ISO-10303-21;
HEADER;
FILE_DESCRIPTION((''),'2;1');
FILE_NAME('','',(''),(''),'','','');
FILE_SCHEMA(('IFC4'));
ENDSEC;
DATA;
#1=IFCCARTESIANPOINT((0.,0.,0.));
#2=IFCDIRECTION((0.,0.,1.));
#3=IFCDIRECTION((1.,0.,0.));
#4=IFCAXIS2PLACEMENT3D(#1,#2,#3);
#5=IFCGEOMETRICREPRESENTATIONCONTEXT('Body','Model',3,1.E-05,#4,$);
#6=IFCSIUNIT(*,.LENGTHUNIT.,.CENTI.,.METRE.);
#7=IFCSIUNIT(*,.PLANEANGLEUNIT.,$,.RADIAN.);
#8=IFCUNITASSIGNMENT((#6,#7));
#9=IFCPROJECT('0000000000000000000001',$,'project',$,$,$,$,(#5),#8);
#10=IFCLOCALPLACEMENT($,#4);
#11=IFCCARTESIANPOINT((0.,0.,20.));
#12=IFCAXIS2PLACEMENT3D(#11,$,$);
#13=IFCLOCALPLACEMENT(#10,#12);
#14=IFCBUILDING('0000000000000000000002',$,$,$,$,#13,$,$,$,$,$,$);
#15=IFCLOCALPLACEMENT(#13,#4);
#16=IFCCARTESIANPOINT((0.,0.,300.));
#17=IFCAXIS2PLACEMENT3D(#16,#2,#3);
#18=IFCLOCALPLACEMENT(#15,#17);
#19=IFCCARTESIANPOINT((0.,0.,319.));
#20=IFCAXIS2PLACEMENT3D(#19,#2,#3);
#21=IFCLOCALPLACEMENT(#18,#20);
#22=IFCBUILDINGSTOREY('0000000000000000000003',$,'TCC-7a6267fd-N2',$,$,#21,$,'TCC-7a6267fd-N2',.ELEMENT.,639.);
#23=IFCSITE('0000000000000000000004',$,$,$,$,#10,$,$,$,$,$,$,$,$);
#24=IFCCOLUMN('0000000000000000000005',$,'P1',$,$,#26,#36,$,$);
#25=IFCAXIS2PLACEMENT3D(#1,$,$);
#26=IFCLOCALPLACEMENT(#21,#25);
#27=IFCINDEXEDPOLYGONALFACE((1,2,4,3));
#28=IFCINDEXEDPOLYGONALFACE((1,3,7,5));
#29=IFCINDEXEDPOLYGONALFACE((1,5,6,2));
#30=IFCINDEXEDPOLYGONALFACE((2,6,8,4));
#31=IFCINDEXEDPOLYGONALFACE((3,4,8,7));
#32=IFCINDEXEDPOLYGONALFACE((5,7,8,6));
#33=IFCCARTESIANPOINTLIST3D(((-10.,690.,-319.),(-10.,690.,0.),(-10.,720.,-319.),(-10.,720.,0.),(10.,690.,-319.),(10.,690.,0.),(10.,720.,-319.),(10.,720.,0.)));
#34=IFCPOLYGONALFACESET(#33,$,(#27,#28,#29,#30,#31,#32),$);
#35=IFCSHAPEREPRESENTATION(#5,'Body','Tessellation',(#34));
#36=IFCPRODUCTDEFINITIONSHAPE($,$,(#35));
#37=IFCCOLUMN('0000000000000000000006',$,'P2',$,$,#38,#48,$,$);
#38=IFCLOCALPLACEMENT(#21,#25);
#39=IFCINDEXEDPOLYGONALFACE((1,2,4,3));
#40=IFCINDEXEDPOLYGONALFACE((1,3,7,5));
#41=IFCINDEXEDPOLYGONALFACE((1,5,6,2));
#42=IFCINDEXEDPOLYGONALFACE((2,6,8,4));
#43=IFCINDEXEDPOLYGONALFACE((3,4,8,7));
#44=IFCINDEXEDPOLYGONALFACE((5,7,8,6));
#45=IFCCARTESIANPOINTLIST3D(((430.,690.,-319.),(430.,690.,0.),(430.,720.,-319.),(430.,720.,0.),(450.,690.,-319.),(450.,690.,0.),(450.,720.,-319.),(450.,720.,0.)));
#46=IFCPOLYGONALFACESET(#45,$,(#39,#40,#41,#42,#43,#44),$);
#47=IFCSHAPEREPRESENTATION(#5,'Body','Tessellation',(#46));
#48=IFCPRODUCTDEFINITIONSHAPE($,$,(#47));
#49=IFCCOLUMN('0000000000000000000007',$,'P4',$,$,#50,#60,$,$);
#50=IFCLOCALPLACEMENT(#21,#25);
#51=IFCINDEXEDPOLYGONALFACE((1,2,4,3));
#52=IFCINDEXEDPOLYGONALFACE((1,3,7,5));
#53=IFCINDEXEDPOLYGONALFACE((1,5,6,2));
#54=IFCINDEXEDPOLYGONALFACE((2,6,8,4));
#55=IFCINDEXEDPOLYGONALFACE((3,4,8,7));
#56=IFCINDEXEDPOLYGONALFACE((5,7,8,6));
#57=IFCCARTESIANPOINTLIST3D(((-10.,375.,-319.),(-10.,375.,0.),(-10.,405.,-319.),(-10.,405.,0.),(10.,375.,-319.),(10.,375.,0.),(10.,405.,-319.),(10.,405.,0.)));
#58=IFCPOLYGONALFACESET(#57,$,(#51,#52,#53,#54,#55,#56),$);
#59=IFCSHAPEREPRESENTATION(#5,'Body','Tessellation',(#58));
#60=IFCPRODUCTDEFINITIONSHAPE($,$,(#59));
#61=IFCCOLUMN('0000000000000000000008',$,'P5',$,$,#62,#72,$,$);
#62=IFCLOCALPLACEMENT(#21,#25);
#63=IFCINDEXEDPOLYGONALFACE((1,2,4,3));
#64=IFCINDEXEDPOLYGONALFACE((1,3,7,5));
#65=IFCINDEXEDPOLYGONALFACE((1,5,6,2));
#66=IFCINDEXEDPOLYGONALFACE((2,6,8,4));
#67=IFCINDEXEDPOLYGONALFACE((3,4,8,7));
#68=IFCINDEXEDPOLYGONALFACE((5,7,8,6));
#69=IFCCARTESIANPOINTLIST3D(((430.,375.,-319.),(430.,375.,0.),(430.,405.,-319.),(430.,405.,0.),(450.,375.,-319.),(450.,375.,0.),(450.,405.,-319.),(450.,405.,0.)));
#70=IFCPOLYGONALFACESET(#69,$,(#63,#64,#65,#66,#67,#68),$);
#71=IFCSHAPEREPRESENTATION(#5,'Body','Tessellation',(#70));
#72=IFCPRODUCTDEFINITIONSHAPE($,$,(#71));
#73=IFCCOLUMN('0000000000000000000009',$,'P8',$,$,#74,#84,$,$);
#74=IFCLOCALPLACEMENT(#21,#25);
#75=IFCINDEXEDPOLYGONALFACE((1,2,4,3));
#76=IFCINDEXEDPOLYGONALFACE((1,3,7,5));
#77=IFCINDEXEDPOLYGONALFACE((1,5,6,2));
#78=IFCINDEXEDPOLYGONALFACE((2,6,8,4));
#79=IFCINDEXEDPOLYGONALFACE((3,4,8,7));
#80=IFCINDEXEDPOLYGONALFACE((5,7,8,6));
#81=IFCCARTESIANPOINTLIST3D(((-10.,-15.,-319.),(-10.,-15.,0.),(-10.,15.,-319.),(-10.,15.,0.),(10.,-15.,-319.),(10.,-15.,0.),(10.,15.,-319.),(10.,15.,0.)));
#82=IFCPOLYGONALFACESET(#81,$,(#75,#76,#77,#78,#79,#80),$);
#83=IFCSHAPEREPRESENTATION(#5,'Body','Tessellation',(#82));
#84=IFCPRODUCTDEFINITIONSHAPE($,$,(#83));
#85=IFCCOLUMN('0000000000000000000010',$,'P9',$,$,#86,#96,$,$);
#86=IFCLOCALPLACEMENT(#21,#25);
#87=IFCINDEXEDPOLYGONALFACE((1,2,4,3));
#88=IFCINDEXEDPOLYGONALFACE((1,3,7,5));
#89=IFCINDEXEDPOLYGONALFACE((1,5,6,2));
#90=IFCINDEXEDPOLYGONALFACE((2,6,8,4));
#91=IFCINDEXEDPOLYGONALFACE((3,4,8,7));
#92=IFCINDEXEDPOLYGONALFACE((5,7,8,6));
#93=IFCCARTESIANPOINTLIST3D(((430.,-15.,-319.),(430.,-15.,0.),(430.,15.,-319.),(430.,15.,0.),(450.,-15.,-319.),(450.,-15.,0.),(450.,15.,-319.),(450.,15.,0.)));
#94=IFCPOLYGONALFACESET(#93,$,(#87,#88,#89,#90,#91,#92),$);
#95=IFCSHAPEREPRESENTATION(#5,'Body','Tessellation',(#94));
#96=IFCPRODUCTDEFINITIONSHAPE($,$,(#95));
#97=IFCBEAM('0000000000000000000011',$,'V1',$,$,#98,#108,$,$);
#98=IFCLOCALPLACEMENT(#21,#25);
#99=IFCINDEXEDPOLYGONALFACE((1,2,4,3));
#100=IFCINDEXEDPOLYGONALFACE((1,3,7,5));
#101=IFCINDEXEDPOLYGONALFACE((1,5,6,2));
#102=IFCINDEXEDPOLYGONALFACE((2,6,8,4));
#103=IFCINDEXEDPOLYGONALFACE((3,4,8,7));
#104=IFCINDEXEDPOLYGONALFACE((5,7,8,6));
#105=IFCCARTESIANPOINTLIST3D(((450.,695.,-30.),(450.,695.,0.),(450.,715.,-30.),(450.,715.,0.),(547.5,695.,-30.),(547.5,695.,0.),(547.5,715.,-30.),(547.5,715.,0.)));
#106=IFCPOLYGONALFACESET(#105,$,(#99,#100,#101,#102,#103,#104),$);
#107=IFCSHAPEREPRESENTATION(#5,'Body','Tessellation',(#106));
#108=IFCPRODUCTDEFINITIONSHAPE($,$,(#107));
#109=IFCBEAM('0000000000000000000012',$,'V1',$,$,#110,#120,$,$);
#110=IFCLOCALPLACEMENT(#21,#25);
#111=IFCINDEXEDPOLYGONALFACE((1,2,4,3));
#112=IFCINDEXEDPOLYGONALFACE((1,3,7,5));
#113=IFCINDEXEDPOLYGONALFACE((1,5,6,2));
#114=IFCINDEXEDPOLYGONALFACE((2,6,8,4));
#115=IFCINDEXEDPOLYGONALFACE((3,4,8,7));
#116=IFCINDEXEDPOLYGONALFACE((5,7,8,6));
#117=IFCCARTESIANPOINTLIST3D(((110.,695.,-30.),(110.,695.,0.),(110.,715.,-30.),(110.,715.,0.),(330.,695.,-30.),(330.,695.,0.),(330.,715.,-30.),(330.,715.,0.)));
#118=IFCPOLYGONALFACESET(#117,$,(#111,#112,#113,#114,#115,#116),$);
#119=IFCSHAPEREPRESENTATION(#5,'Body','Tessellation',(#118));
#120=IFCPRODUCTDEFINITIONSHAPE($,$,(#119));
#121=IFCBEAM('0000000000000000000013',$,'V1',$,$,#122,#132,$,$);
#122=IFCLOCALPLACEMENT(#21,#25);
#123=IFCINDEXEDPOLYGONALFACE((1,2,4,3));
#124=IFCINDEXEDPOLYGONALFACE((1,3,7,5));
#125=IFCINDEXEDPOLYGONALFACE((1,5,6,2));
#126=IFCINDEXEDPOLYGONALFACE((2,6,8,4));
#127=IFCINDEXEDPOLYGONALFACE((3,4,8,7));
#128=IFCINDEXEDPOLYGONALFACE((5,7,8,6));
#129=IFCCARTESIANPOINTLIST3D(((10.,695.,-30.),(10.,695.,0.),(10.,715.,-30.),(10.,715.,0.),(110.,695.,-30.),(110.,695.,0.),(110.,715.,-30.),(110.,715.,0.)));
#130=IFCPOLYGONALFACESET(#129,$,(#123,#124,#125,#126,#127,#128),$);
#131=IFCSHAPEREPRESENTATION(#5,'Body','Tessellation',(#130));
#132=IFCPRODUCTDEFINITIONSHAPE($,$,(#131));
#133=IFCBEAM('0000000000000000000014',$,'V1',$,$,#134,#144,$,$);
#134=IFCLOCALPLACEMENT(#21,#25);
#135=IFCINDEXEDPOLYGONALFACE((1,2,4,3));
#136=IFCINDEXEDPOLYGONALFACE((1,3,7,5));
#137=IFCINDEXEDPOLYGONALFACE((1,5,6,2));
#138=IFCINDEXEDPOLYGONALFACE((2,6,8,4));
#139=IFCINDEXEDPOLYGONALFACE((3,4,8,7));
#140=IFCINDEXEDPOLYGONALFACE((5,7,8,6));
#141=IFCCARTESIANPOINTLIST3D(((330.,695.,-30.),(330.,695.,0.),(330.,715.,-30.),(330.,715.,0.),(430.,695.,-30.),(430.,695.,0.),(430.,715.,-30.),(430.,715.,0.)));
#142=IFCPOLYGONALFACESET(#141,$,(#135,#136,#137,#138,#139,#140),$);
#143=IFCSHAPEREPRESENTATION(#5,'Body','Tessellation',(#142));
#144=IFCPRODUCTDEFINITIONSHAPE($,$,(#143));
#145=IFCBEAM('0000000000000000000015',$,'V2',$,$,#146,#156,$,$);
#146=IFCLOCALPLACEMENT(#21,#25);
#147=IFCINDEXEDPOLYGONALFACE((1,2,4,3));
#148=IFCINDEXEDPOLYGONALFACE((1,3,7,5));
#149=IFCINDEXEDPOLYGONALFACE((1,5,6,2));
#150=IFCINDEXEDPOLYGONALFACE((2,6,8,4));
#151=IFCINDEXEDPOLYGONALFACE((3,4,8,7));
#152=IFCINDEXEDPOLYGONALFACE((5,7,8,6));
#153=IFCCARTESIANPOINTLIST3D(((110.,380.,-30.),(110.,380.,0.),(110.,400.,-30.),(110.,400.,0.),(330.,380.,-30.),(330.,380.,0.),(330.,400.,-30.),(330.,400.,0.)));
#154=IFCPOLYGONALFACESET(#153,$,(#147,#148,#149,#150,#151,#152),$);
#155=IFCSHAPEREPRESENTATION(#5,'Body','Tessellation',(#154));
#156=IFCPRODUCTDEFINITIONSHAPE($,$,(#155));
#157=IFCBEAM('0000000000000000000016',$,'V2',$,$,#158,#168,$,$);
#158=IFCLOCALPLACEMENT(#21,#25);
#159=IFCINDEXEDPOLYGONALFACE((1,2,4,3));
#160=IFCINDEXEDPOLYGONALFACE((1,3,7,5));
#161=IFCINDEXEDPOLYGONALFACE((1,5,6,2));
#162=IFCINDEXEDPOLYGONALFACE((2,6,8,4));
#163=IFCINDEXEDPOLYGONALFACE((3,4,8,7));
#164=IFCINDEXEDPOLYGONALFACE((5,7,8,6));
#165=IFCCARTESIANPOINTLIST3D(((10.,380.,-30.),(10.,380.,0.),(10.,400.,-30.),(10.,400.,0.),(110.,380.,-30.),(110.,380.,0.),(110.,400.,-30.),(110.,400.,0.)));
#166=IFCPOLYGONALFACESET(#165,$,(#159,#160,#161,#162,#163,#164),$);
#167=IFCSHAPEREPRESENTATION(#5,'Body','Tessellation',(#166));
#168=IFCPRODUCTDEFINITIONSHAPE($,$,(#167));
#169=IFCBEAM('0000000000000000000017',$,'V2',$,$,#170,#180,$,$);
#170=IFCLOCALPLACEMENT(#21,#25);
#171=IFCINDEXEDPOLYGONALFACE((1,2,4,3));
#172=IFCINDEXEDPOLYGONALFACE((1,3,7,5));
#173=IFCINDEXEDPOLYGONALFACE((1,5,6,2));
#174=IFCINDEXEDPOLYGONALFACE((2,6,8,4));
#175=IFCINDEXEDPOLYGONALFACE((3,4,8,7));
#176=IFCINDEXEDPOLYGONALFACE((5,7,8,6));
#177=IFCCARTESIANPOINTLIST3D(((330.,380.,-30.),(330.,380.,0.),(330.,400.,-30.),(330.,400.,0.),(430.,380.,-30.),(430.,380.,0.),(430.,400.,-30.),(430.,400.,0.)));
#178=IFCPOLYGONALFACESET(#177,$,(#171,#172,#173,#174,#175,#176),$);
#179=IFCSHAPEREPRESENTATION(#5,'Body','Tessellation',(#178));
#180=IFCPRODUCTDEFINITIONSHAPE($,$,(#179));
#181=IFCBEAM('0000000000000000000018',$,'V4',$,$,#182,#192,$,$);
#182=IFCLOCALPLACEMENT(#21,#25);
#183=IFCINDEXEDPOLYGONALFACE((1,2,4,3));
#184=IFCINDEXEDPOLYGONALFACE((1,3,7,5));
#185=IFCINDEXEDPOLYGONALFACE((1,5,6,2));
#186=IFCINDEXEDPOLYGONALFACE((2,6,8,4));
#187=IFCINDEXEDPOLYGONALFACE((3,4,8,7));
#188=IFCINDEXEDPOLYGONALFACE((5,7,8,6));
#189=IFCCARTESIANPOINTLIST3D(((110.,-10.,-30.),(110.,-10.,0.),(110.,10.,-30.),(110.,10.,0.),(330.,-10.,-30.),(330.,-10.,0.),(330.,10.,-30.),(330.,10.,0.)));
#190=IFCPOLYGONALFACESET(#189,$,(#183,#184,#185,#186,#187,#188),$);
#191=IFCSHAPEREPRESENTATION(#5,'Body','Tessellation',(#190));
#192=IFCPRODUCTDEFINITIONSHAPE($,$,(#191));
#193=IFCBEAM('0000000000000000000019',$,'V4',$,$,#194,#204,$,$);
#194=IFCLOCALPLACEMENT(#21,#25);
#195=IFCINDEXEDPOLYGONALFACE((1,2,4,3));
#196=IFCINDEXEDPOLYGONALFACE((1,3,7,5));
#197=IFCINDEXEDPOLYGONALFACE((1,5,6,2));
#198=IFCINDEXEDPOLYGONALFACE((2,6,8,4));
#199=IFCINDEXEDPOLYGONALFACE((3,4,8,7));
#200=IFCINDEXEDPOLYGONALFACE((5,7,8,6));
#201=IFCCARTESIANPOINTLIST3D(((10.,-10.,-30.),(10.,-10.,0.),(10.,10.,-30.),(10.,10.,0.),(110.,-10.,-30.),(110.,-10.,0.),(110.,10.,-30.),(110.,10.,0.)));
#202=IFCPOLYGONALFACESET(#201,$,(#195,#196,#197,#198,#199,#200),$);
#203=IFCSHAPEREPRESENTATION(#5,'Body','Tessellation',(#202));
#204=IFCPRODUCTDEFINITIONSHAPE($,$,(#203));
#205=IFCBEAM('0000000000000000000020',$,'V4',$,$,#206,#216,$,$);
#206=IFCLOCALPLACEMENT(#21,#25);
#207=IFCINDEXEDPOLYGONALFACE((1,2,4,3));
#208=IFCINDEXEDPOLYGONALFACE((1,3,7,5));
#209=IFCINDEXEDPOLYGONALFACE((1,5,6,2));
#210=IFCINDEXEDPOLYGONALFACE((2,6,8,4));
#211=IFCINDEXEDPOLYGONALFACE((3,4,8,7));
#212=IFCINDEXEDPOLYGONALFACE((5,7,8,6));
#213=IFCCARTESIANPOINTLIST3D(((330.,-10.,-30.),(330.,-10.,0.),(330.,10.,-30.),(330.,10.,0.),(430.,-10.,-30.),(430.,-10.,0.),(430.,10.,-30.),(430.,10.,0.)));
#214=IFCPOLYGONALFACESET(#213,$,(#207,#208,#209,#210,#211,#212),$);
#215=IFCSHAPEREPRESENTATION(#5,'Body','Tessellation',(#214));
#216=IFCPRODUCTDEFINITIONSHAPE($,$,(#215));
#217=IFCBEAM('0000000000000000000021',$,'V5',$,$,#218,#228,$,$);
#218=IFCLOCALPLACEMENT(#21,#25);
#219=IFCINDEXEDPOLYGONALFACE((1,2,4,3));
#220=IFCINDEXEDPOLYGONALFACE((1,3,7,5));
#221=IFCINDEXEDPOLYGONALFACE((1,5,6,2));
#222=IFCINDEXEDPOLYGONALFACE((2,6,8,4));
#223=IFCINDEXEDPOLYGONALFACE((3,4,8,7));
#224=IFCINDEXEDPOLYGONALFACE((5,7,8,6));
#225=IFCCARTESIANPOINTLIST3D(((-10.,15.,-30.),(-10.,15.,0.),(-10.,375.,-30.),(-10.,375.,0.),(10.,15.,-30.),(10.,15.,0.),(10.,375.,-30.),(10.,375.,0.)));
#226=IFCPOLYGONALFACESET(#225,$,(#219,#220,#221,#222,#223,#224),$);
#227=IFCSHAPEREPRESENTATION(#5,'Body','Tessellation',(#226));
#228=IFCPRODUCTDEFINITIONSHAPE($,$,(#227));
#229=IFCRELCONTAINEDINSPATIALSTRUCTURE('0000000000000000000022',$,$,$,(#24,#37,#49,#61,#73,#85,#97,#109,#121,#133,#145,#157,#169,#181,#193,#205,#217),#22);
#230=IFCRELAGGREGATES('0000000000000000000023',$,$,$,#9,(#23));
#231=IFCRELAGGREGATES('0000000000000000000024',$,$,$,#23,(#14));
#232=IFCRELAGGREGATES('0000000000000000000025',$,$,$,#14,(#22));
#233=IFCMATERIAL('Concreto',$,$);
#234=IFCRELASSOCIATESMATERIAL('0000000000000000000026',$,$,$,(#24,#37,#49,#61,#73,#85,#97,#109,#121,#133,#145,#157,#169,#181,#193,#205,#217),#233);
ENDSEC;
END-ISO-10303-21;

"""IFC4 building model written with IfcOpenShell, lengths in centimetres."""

from ifc_helpers import new_model, si_unit, frame, origin_with_axes, origin_2d_with_axis, place, context, project, spatial, rectangle, extrude, material, element, save


model = new_model("IFC4")

# Units and contexts
model_context = context("Model", 3, precision=1e-05, world=origin_with_axes(), identifier="Body")
ifc_project = project(units=[si_unit("LENGTHUNIT", "METRE", prefix="CENTI"), si_unit("PLANEANGLEUNIT", "RADIAN")], contexts=[model_context])

# Site, building, storey
site_placement = place(None, origin_with_axes())
site = spatial("IfcSite", under=ifc_project, at=site_placement)
building_placement = place(site_placement, frame((0.0, 0.0, 20.0)))
building = spatial("IfcBuilding", under=site, at=building_placement)
placement_1 = place(building_placement, origin_with_axes())
placement_2 = place(placement_1, frame((0.0, 0.0, 300.0), z_axis=(0.0, 0.0, 1.0), x_axis=(1.0, 0.0, 0.0)))
storey_placement = place(placement_2, frame((0.0, 0.0, 319.0), z_axis=(0.0, 0.0, 1.0), x_axis=(1.0, 0.0, 0.0)))
storey = spatial("IfcBuildingStorey", under=building, at=storey_placement, Name="TCC-7a6267fd-N2", LongName="TCC-7a6267fd-N2", CompositionType="ELEMENT", Elevation=639.0)

# Columns
ifc_material = material(Name="Concreto")
for number, where, z_axis, x_axis, name in (
    (1, (0.0, 705.0, 0.0), (0.0, 0.0, 1.0), (1.0, 0.0, 0.0), "P1"),
    (2, (440.0, 705.0, 0.0), (0.0, 0.0, 1.0), (1.0, 0.0, 0.0), "P2"),
    (3, (0.0, 390.0, 0.0), (0.0, 0.0, 1.0), (1.0, 0.0, 0.0), "P4"),
    (4, (440.0, 390.0, 0.0), (0.0, 0.0, 1.0), (1.0, 0.0, 0.0), "P5"),
    (5, (0.0, 0.0, 0.0), (0.0, 0.0, 1.0), (1.0, 0.0, 0.0), "P8"),
    (6, (440.0, 0.0, 0.0), (0.0, 0.0, 1.0), (1.0, 0.0, 0.0), "P9"),
):
    element("IfcColumn", number, at=place(storey_placement, frame(where, z_axis=z_axis, x_axis=x_axis)), inside=storey, material=ifc_material, Name=name, context=model_context, shape_type="SolidModel", body=[
        extrude(rectangle(XDim=20.0, YDim=30.0, at=origin_2d_with_axis()), origin_with_axes(), (0.0, 0.0, -1.0), 319.0),
    ])

# Beams
beam_1_placement = place(storey_placement, frame((498.75, 705.0, 0.0), z_axis=(0.0, 0.0, 1.0), x_axis=(1.0, 0.0, 0.0)))
element("IfcBeam", 7, at=beam_1_placement, inside=storey, material=ifc_material, Name="V1", context=model_context, shape_type="SolidModel", body=[
    extrude(rectangle(XDim=20.0, YDim=30.0, at=origin_2d_with_axis()), frame((48.75, 0.0, -15.0), z_axis=(-1.0, 0.0, 0.0), x_axis=(0.0, 1.0, 0.0)), (0.0, 0.0, 1.0), 97.5),
])
beam_2_placement = place(storey_placement, frame((220.0, 705.0, 0.0), z_axis=(0.0, 0.0, 1.0), x_axis=(1.0, 0.0, 0.0)))
element("IfcBeam", 8, at=beam_2_placement, inside=storey, material=ifc_material, Name="V1", context=model_context, shape_type="SolidModel", body=[
    extrude(rectangle(XDim=20.0, YDim=30.0, at=origin_2d_with_axis()), frame((110.0, 0.0, -15.0), z_axis=(-1.0, 0.0, 0.0), x_axis=(0.0, 1.0, 0.0)), (0.0, 0.0, 1.0), 220.0),
])
for number, where, z_axis, x_axis, name in (
    (9, (60.0, 705.0, 0.0), (0.0, 0.0, 1.0), (1.0, 0.0, 0.0), "V1"),
    (10, (380.0, 705.0, 0.0), (0.0, 0.0, 1.0), (1.0, 0.0, 0.0), "V1"),
):
    element("IfcBeam", number, at=place(storey_placement, frame(where, z_axis=z_axis, x_axis=x_axis)), inside=storey, material=ifc_material, Name=name, context=model_context, shape_type="SolidModel", body=[
        extrude(rectangle(XDim=20.0, YDim=30.0, at=origin_2d_with_axis()), frame((50.0, 0.0, -15.0), z_axis=(-1.0, 0.0, 0.0), x_axis=(0.0, 1.0, 0.0)), (0.0, 0.0, 1.0), 100.0),
    ])
beam_3_placement = place(storey_placement, frame((220.0, 390.0, 0.0), z_axis=(0.0, 0.0, 1.0), x_axis=(1.0, 0.0, 0.0)))
element("IfcBeam", 11, at=beam_3_placement, inside=storey, material=ifc_material, Name="V2", context=model_context, shape_type="SolidModel", body=[
    extrude(rectangle(XDim=20.0, YDim=30.0, at=origin_2d_with_axis()), frame((110.0, 0.0, -15.0), z_axis=(-1.0, 0.0, 0.0), x_axis=(0.0, 1.0, 0.0)), (0.0, 0.0, 1.0), 220.0),
])
for number, where, z_axis, x_axis, name in (
    (12, (60.0, 390.0, 0.0), (0.0, 0.0, 1.0), (1.0, 0.0, 0.0), "V2"),
    (13, (380.0, 390.0, 0.0), (0.0, 0.0, 1.0), (1.0, 0.0, 0.0), "V2"),
):
    element("IfcBeam", number, at=place(storey_placement, frame(where, z_axis=z_axis, x_axis=x_axis)), inside=storey, material=ifc_material, Name=name, context=model_context, shape_type="SolidModel", body=[
        extrude(rectangle(XDim=20.0, YDim=30.0, at=origin_2d_with_axis()), frame((50.0, 0.0, -15.0), z_axis=(-1.0, 0.0, 0.0), x_axis=(0.0, 1.0, 0.0)), (0.0, 0.0, 1.0), 100.0),
    ])
beam_4_placement = place(storey_placement, frame((220.0, 0.0, 0.0), z_axis=(0.0, 0.0, 1.0), x_axis=(1.0, 0.0, 0.0)))
element("IfcBeam", 14, at=beam_4_placement, inside=storey, material=ifc_material, Name="V4", context=model_context, shape_type="SolidModel", body=[
    extrude(rectangle(XDim=20.0, YDim=30.0, at=origin_2d_with_axis()), frame((110.0, 0.0, -15.0), z_axis=(-1.0, 0.0, 0.0), x_axis=(0.0, 1.0, 0.0)), (0.0, 0.0, 1.0), 220.0),
])
for number, where, z_axis, x_axis, name in (
    (15, (60.0, 0.0, 0.0), (0.0, 0.0, 1.0), (1.0, 0.0, 0.0), "V4"),
    (16, (380.0, 0.0, 0.0), (0.0, 0.0, 1.0), (1.0, 0.0, 0.0), "V4"),
):
    element("IfcBeam", number, at=place(storey_placement, frame(where, z_axis=z_axis, x_axis=x_axis)), inside=storey, material=ifc_material, Name=name, context=model_context, shape_type="SolidModel", body=[
        extrude(rectangle(XDim=20.0, YDim=30.0, at=origin_2d_with_axis()), frame((50.0, 0.0, -15.0), z_axis=(-1.0, 0.0, 0.0), x_axis=(0.0, 1.0, 0.0)), (0.0, 0.0, 1.0), 100.0),
    ])
beam_5_placement = place(storey_placement, frame((0.0, 195.0, 0.0), z_axis=(0.0, 0.0, 1.0), x_axis=(1.0, 0.0, 0.0)))
element("IfcBeam", 17, at=beam_5_placement, inside=storey, material=ifc_material, Name="V5", context=model_context, shape_type="SolidModel", body=[
    extrude(rectangle(XDim=20.0, YDim=30.0, at=origin_2d_with_axis()), frame((0.0, -180.0, -15.0), z_axis=(0.0, 1.0, 0.0), x_axis=(-1.0, 0.0, 0.0)), (0.0, 0.0, 1.0), 360.0),
])

save(model, "model.ifc")
